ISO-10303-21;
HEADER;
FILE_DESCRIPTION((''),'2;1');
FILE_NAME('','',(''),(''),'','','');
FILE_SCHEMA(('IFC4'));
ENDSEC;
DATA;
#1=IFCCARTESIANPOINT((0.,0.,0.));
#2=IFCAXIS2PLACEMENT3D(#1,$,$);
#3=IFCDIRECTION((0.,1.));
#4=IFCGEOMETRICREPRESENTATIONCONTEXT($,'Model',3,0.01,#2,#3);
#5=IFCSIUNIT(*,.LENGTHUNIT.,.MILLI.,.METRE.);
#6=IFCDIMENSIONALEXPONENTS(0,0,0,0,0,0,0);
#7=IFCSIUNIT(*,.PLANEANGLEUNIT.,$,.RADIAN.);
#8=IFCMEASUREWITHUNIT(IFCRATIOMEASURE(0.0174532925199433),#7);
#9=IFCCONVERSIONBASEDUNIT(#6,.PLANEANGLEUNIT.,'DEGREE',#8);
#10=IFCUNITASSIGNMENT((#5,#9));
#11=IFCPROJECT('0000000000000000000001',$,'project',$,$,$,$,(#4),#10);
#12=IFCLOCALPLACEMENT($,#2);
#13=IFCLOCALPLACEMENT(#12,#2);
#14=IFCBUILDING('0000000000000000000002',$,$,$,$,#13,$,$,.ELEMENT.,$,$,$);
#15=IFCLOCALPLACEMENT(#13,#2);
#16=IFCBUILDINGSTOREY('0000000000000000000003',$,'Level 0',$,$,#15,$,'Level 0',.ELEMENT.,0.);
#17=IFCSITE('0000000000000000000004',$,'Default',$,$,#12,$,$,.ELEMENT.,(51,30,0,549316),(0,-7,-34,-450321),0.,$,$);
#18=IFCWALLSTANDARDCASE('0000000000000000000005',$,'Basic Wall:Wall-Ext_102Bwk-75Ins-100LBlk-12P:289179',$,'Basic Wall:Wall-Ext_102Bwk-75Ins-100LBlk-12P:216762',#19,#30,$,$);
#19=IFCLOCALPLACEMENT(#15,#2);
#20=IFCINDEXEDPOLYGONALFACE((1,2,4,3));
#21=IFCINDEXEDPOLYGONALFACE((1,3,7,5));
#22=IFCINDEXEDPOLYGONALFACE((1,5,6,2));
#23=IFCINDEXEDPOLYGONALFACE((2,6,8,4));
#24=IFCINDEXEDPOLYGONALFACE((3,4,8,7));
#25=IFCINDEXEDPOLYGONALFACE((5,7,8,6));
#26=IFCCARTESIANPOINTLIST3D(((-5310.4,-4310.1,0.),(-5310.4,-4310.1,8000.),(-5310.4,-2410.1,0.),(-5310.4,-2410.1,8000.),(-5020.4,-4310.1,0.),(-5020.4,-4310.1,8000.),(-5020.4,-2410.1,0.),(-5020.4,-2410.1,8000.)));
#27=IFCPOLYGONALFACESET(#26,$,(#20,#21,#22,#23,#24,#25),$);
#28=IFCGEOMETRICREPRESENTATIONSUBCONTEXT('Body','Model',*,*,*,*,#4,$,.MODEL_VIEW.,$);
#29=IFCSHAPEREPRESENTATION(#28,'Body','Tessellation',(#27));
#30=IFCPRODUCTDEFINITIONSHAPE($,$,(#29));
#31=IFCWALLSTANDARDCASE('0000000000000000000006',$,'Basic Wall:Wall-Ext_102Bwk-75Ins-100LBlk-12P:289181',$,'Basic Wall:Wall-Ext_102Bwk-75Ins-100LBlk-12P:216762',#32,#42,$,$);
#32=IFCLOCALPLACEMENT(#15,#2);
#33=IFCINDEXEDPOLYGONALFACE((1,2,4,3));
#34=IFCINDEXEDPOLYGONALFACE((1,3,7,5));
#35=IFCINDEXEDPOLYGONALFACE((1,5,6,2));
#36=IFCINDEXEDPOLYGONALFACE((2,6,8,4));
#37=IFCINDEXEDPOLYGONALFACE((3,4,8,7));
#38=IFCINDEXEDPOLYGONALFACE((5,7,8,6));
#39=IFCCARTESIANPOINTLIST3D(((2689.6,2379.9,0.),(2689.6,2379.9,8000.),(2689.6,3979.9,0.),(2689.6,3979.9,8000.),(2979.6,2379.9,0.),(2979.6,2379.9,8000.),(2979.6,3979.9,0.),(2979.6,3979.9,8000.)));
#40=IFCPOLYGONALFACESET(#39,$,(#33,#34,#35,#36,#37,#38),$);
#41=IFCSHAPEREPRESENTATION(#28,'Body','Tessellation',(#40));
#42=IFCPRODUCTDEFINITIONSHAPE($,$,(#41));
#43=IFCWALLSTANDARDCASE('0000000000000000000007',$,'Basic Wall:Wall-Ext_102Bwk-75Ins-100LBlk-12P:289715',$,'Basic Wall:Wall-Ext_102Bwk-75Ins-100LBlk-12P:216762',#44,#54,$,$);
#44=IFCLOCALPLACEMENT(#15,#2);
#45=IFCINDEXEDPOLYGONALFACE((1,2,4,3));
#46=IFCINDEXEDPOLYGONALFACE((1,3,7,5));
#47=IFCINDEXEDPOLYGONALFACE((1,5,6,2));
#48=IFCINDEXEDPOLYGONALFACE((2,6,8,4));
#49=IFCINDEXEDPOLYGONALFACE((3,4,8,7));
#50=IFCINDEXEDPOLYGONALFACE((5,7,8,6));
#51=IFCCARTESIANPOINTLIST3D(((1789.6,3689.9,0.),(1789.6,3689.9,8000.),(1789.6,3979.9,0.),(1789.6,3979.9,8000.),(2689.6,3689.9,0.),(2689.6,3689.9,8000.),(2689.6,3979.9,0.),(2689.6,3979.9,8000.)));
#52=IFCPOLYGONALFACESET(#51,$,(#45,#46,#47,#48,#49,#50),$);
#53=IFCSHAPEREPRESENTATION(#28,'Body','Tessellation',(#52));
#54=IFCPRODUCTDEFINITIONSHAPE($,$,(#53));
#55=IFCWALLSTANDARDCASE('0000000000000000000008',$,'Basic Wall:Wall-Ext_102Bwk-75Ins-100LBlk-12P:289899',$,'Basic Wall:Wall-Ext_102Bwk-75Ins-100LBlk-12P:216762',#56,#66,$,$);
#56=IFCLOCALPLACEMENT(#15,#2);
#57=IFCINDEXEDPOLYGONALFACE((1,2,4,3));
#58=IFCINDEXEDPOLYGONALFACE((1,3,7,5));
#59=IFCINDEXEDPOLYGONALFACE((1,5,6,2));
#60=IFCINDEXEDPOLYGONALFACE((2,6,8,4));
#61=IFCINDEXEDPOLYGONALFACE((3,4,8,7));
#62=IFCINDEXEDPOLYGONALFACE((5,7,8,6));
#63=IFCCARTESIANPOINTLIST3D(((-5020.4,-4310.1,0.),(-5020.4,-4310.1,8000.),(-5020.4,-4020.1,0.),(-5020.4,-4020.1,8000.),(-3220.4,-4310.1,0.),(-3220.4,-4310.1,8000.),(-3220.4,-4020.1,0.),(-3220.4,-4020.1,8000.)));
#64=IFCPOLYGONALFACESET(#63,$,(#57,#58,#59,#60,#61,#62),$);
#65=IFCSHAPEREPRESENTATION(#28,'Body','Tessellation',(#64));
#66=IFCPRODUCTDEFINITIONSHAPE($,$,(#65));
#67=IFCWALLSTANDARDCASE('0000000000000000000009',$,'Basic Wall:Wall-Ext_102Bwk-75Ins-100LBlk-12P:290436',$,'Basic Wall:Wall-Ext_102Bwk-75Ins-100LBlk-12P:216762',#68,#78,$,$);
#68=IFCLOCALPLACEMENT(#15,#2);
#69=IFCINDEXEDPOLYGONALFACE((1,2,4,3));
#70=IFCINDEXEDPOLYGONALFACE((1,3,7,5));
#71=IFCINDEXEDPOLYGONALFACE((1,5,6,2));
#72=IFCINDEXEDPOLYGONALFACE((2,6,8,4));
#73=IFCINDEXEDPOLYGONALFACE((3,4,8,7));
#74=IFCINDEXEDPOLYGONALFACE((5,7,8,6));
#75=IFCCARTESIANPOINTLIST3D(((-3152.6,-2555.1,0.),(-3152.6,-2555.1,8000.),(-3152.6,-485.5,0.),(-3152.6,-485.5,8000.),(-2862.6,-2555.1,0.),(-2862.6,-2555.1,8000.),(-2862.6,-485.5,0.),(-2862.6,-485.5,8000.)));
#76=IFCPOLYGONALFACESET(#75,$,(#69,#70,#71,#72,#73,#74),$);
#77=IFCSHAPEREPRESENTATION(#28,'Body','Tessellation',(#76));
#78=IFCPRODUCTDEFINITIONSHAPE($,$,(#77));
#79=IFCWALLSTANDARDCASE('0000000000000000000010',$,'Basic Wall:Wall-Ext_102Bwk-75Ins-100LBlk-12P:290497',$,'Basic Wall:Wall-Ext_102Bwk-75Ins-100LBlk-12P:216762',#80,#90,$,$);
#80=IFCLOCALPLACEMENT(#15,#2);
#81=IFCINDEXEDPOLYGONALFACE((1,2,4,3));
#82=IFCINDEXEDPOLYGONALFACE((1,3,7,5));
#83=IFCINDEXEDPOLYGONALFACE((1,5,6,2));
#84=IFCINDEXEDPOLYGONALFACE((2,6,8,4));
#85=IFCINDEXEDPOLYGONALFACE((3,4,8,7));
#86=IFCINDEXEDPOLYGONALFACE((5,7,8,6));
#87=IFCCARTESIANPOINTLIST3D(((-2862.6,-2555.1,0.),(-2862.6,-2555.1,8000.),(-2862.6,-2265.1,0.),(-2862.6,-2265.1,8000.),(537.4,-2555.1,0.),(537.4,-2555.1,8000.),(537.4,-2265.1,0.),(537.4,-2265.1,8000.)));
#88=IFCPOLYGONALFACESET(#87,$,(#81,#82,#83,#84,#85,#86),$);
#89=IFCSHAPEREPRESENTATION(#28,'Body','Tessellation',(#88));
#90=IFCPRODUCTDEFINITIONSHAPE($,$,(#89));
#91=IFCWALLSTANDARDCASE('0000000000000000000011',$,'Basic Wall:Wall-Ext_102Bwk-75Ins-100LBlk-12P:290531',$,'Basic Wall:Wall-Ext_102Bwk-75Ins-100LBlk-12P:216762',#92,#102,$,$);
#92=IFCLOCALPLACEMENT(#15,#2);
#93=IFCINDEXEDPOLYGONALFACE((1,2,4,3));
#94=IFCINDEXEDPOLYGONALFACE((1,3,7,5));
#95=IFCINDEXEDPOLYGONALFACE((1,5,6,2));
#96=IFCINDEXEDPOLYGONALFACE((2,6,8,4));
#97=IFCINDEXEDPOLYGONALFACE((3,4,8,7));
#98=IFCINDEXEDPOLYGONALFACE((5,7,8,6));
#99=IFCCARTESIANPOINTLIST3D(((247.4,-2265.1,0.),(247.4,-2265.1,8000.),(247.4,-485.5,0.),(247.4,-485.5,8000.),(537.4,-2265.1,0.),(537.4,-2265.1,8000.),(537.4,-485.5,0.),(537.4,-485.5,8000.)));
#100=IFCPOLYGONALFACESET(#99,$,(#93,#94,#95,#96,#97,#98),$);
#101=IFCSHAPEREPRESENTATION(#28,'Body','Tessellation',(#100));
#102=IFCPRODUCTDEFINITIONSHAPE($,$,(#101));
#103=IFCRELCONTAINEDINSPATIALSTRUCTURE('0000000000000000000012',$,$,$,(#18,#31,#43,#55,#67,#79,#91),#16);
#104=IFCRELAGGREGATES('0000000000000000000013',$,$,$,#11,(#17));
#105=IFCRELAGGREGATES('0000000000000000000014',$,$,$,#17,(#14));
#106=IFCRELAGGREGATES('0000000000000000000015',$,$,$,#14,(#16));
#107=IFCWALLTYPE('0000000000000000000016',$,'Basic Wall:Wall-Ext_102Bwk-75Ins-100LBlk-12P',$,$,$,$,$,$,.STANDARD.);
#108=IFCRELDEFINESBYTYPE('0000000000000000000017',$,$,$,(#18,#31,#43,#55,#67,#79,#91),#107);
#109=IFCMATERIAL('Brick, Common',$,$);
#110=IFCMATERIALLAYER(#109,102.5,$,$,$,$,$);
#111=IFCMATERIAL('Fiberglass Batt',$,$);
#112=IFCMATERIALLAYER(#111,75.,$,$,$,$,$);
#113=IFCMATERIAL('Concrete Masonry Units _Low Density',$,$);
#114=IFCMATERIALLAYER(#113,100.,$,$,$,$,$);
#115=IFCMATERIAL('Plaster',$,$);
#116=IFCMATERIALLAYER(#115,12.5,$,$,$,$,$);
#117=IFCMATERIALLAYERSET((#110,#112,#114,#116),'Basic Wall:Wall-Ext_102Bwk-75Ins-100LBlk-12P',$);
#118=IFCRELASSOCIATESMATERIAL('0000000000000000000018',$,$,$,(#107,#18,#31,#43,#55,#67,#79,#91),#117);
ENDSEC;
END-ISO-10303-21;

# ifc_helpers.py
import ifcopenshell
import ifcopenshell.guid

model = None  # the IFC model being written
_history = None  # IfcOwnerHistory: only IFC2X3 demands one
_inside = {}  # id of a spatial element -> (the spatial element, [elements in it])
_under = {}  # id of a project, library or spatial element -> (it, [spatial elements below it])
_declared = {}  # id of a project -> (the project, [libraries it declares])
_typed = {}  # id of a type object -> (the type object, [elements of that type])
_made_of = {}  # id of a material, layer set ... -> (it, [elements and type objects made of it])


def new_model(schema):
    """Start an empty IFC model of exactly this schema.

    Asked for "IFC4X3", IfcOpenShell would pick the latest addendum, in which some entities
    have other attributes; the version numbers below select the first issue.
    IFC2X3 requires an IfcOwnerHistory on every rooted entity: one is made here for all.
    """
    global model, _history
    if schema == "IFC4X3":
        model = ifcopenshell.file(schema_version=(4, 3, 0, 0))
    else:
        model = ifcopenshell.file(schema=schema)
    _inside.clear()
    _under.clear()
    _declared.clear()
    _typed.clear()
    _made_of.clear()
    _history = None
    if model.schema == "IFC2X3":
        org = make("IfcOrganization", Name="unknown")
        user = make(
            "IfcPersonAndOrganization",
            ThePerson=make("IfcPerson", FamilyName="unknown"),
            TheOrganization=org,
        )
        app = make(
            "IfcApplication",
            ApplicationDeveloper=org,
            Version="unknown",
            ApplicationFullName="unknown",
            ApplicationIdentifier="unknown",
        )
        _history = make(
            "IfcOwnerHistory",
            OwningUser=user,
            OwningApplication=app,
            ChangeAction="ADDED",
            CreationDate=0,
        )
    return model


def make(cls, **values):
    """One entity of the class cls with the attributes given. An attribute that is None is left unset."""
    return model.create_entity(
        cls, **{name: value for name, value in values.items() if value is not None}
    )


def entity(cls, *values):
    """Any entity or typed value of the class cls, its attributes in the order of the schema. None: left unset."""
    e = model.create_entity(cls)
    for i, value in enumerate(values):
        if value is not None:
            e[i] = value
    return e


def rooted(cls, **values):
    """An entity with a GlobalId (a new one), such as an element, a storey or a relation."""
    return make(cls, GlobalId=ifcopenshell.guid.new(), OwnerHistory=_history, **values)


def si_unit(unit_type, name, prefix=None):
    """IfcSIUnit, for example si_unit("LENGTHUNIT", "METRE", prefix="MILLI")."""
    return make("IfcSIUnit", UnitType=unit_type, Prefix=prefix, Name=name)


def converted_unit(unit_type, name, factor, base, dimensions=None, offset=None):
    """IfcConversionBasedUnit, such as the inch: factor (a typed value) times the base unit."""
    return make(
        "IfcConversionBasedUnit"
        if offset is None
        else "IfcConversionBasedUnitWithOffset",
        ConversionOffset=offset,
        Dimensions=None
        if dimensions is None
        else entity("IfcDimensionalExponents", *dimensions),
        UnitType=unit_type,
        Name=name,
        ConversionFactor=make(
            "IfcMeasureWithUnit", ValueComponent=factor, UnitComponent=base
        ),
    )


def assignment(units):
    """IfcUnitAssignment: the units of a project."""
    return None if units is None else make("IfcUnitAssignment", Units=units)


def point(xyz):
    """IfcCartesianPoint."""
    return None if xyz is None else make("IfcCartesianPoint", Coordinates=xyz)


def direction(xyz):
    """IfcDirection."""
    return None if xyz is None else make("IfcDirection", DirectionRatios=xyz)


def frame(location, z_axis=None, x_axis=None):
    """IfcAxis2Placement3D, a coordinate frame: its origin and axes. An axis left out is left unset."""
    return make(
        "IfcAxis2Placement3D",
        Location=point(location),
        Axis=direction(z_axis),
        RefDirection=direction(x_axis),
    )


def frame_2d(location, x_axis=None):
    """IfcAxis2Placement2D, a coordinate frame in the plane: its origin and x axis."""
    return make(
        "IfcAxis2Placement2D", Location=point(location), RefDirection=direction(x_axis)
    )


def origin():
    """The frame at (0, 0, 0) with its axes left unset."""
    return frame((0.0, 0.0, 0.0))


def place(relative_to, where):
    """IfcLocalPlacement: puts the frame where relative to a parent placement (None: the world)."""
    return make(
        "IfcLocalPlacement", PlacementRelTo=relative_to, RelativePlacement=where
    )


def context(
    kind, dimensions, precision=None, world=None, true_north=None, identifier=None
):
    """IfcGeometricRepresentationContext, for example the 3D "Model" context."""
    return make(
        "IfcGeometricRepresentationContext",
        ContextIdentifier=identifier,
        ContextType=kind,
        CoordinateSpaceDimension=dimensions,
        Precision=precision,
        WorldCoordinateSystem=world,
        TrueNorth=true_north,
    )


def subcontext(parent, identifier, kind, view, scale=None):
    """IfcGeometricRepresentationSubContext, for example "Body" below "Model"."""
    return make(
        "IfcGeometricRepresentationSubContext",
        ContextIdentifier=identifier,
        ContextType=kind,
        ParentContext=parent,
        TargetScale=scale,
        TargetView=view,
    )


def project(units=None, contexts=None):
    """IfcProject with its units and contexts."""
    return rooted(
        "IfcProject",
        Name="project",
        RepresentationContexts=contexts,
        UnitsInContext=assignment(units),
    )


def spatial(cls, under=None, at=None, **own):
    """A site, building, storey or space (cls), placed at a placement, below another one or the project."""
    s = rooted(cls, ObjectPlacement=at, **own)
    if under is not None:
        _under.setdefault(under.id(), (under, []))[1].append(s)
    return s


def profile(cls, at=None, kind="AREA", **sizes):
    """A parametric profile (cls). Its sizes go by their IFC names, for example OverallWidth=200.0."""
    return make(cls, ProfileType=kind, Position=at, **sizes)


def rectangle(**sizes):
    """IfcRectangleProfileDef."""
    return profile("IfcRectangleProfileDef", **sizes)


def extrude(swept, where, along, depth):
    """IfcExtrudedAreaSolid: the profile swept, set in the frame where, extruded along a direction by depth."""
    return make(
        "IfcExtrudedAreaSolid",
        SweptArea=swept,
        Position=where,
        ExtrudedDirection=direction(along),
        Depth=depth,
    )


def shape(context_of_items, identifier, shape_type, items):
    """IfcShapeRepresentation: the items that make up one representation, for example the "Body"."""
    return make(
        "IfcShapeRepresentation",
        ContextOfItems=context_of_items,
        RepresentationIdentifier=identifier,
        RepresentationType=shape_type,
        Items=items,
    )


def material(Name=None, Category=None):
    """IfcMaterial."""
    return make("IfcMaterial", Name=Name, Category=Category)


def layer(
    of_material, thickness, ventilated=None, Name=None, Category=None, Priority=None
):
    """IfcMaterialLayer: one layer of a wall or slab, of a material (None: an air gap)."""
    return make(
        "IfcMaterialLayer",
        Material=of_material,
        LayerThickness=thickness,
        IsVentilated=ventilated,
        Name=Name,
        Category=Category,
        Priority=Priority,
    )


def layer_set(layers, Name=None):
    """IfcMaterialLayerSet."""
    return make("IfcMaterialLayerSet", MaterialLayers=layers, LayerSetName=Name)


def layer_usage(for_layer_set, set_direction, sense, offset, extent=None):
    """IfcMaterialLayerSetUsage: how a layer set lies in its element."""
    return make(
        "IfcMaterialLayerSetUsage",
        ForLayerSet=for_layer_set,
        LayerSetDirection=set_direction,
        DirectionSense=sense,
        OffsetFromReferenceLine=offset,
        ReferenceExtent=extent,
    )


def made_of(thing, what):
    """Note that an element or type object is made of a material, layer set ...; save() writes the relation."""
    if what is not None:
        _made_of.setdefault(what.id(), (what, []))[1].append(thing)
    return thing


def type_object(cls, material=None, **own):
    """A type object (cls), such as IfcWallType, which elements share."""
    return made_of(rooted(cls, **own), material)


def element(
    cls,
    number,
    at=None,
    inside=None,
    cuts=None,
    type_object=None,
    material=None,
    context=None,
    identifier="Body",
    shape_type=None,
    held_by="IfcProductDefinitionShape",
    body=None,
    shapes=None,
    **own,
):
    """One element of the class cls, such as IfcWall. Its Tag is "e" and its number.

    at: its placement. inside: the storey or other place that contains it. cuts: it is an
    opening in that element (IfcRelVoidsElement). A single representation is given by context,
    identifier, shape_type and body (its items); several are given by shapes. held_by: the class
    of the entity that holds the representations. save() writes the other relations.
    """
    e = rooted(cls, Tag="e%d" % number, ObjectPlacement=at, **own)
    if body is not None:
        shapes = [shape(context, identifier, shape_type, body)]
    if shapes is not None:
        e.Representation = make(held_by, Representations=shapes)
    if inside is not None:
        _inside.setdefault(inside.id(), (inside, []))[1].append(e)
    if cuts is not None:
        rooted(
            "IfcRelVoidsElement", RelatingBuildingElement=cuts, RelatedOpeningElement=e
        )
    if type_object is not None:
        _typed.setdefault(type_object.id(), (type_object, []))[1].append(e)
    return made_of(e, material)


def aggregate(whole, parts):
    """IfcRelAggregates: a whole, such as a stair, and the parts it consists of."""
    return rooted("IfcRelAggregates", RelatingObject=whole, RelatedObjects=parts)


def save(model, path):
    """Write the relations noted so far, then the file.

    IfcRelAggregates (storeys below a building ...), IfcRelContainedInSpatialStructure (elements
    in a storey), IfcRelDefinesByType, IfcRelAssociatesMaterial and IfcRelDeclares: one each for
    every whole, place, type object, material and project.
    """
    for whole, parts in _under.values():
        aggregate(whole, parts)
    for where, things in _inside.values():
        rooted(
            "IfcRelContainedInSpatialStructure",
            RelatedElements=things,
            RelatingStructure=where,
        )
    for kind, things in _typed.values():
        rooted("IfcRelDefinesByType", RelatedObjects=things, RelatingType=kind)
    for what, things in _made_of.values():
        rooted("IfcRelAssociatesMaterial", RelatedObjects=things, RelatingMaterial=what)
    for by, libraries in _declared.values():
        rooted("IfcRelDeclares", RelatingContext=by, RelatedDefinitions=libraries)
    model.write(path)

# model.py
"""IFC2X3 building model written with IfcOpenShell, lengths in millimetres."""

from ifc_helpers import new_model, entity, si_unit, converted_unit, direction, frame, frame_2d, origin, place, context, subcontext, project, spatial, rectangle, extrude, material, layer, layer_set, layer_usage, type_object, element, save


model = new_model("IFC2X3")

# Units and contexts
model_context = context("Model", 3, precision=0.01, world=origin(), true_north=direction((0.0, 1.0)))
body_context = subcontext(model_context, "Body", "Model", "MODEL_VIEW")
ifc_project = project(units=[si_unit("LENGTHUNIT", "METRE", prefix="MILLI"), converted_unit("PLANEANGLEUNIT", "DEGREE", entity("IfcRatioMeasure", 0.0174532925199433), si_unit("PLANEANGLEUNIT", "RADIAN"), dimensions=[0, 0, 0, 0, 0, 0, 0])], contexts=[model_context])

# Site, building, storey
site_placement = place(None, origin())
site = spatial("IfcSite", under=ifc_project, at=site_placement, Name="Default", CompositionType="ELEMENT", RefLatitude=(51, 30, 0, 549316), RefLongitude=(0, -7, -34, -450321), RefElevation=0.0)
building_placement = place(site_placement, origin())
building = spatial("IfcBuilding", under=site, at=building_placement, CompositionType="ELEMENT")
storey_placement = place(building_placement, origin())
storey = spatial("IfcBuildingStorey", under=building, at=storey_placement, Name="Level 0", LongName="Level 0", CompositionType="ELEMENT", Elevation=0.0)

# Walls
ifc_material_1 = material(Name="Brick, Common")
ifc_layer_1 = layer(ifc_material_1, 102.5)
ifc_material_2 = material(Name="Fiberglass Batt")
ifc_layer_2 = layer(ifc_material_2, 75.0)
ifc_material_3 = material(Name="Concrete Masonry Units _Low Density")
ifc_layer_3 = layer(ifc_material_3, 100.0)
ifc_material_4 = material(Name="Plaster")
ifc_layer_4 = layer(ifc_material_4, 12.5)
ifc_layer_set = layer_set([ifc_layer_1, ifc_layer_2, ifc_layer_3, ifc_layer_4], Name="Basic Wall:Wall-Ext_102Bwk-75Ins-100LBlk-12P")
ifc_layer_usage_1 = layer_usage(ifc_layer_set, "AXIS2", "NEGATIVE", 145.0)
wall_type = type_object("IfcWallType", Name="Basic Wall:Wall-Ext_102Bwk-75Ins-100LBlk-12P", PredefinedType="STANDARD", material=ifc_layer_set)
wall_1_placement = place(storey_placement, frame((-5165.4, -4310.1, 0.0), z_axis=(0.0, 0.0, 1.0), x_axis=(0.0, 1.0, 0.0)))
element("IfcWallStandardCase", 1, at=wall_1_placement, inside=storey, type_object=wall_type, material=ifc_layer_usage_1, Name="Basic Wall:Wall-Ext_102Bwk-75Ins-100LBlk-12P:289179", ObjectType="Basic Wall:Wall-Ext_102Bwk-75Ins-100LBlk-12P:216762", context=body_context, shape_type="SweptSolid", body=[
    extrude(rectangle(XDim=1900.0, YDim=290.0, at=frame_2d((950.0, 0.0), x_axis=(-1.0, 0.0))), origin(), (0.0, 0.0, 1.0), 8000.0),
])
ifc_layer_usage_2 = layer_usage(ifc_layer_set, "AXIS2", "NEGATIVE", 145.0)
wall_2_placement = place(storey_placement, frame((2834.6, 3979.9, 0.0), z_axis=(0.0, 0.0, 1.0), x_axis=(0.0, -1.0, 0.0)))
element("IfcWallStandardCase", 2, at=wall_2_placement, inside=storey, type_object=wall_type, material=ifc_layer_usage_2, Name="Basic Wall:Wall-Ext_102Bwk-75Ins-100LBlk-12P:289181", ObjectType="Basic Wall:Wall-Ext_102Bwk-75Ins-100LBlk-12P:216762", context=body_context, shape_type="SweptSolid", body=[
    extrude(rectangle(XDim=1600.0, YDim=290.0, at=frame_2d((800.0, 0.0), x_axis=(-1.0, 0.0))), origin(), (0.0, 0.0, 1.0), 8000.0),
])
ifc_layer_usage_3 = layer_usage(ifc_layer_set, "AXIS2", "NEGATIVE", 145.0)
wall_3_placement = place(storey_placement, frame((1789.6, 3834.9, 0.0)))
element("IfcWallStandardCase", 3, at=wall_3_placement, inside=storey, type_object=wall_type, material=ifc_layer_usage_3, Name="Basic Wall:Wall-Ext_102Bwk-75Ins-100LBlk-12P:289715", ObjectType="Basic Wall:Wall-Ext_102Bwk-75Ins-100LBlk-12P:216762", context=body_context, shape_type="SweptSolid", body=[
    extrude(rectangle(XDim=900.0, YDim=290.0, at=frame_2d((450.0, 0.0), x_axis=(-1.0, 0.0))), origin(), (0.0, 0.0, 1.0), 8000.0),
])
ifc_layer_usage_4 = layer_usage(ifc_layer_set, "AXIS2", "NEGATIVE", 145.0)
wall_4_placement = place(storey_placement, frame((-3220.4, -4165.1, 0.0), z_axis=(0.0, 0.0, 1.0), x_axis=(-1.0, 0.0, 0.0)))
element("IfcWallStandardCase", 4, at=wall_4_placement, inside=storey, type_object=wall_type, material=ifc_layer_usage_4, Name="Basic Wall:Wall-Ext_102Bwk-75Ins-100LBlk-12P:289899", ObjectType="Basic Wall:Wall-Ext_102Bwk-75Ins-100LBlk-12P:216762", context=body_context, shape_type="SweptSolid", body=[
    extrude(rectangle(XDim=1800.0, YDim=290.0, at=frame_2d((900.0, 0.0), x_axis=(-1.0, 0.0))), origin(), (0.0, 0.0, 1.0), 8000.0),
])
ifc_layer_usage_5 = layer_usage(ifc_layer_set, "AXIS2", "NEGATIVE", 145.0)
wall_5_placement = place(storey_placement, frame((-3007.6, -485.5, 0.0), z_axis=(0.0, 0.0, 1.0), x_axis=(0.0, -1.0, 0.0)))
element("IfcWallStandardCase", 5, at=wall_5_placement, inside=storey, type_object=wall_type, material=ifc_layer_usage_5, Name="Basic Wall:Wall-Ext_102Bwk-75Ins-100LBlk-12P:290436", ObjectType="Basic Wall:Wall-Ext_102Bwk-75Ins-100LBlk-12P:216762", context=body_context, shape_type="SweptSolid", body=[
    extrude(rectangle(XDim=2069.6, YDim=290.0, at=frame_2d((1034.8, 0.0), x_axis=(-1.0, 0.0))), origin(), (0.0, 0.0, 1.0), 8000.0),
])
ifc_layer_usage_6 = layer_usage(ifc_layer_set, "AXIS2", "NEGATIVE", 145.0)
wall_6_placement = place(storey_placement, frame((-2862.6, -2410.1, 0.0)))
element("IfcWallStandardCase", 6, at=wall_6_placement, inside=storey, type_object=wall_type, material=ifc_layer_usage_6, Name="Basic Wall:Wall-Ext_102Bwk-75Ins-100LBlk-12P:290497", ObjectType="Basic Wall:Wall-Ext_102Bwk-75Ins-100LBlk-12P:216762", context=body_context, shape_type="SweptSolid", body=[
    extrude(rectangle(XDim=3400.0, YDim=290.0, at=frame_2d((1700.0, 0.0), x_axis=(-1.0, 0.0))), origin(), (0.0, 0.0, 1.0), 8000.0),
])
ifc_layer_usage_7 = layer_usage(ifc_layer_set, "AXIS2", "NEGATIVE", 145.0)
wall_7_placement = place(storey_placement, frame((392.4, -2265.1, 0.0), z_axis=(0.0, 0.0, 1.0), x_axis=(0.0, 1.0, 0.0)))
element("IfcWallStandardCase", 7, at=wall_7_placement, inside=storey, type_object=wall_type, material=ifc_layer_usage_7, Name="Basic Wall:Wall-Ext_102Bwk-75Ins-100LBlk-12P:290531", ObjectType="Basic Wall:Wall-Ext_102Bwk-75Ins-100LBlk-12P:216762", context=body_context, shape_type="SweptSolid", body=[
    extrude(rectangle(XDim=1779.6, YDim=290.0, at=frame_2d((889.8, 0.0), x_axis=(-1.0, 0.0))), origin(), (0.0, 0.0, 1.0), 8000.0),
])

save(model, "model.ifc")
